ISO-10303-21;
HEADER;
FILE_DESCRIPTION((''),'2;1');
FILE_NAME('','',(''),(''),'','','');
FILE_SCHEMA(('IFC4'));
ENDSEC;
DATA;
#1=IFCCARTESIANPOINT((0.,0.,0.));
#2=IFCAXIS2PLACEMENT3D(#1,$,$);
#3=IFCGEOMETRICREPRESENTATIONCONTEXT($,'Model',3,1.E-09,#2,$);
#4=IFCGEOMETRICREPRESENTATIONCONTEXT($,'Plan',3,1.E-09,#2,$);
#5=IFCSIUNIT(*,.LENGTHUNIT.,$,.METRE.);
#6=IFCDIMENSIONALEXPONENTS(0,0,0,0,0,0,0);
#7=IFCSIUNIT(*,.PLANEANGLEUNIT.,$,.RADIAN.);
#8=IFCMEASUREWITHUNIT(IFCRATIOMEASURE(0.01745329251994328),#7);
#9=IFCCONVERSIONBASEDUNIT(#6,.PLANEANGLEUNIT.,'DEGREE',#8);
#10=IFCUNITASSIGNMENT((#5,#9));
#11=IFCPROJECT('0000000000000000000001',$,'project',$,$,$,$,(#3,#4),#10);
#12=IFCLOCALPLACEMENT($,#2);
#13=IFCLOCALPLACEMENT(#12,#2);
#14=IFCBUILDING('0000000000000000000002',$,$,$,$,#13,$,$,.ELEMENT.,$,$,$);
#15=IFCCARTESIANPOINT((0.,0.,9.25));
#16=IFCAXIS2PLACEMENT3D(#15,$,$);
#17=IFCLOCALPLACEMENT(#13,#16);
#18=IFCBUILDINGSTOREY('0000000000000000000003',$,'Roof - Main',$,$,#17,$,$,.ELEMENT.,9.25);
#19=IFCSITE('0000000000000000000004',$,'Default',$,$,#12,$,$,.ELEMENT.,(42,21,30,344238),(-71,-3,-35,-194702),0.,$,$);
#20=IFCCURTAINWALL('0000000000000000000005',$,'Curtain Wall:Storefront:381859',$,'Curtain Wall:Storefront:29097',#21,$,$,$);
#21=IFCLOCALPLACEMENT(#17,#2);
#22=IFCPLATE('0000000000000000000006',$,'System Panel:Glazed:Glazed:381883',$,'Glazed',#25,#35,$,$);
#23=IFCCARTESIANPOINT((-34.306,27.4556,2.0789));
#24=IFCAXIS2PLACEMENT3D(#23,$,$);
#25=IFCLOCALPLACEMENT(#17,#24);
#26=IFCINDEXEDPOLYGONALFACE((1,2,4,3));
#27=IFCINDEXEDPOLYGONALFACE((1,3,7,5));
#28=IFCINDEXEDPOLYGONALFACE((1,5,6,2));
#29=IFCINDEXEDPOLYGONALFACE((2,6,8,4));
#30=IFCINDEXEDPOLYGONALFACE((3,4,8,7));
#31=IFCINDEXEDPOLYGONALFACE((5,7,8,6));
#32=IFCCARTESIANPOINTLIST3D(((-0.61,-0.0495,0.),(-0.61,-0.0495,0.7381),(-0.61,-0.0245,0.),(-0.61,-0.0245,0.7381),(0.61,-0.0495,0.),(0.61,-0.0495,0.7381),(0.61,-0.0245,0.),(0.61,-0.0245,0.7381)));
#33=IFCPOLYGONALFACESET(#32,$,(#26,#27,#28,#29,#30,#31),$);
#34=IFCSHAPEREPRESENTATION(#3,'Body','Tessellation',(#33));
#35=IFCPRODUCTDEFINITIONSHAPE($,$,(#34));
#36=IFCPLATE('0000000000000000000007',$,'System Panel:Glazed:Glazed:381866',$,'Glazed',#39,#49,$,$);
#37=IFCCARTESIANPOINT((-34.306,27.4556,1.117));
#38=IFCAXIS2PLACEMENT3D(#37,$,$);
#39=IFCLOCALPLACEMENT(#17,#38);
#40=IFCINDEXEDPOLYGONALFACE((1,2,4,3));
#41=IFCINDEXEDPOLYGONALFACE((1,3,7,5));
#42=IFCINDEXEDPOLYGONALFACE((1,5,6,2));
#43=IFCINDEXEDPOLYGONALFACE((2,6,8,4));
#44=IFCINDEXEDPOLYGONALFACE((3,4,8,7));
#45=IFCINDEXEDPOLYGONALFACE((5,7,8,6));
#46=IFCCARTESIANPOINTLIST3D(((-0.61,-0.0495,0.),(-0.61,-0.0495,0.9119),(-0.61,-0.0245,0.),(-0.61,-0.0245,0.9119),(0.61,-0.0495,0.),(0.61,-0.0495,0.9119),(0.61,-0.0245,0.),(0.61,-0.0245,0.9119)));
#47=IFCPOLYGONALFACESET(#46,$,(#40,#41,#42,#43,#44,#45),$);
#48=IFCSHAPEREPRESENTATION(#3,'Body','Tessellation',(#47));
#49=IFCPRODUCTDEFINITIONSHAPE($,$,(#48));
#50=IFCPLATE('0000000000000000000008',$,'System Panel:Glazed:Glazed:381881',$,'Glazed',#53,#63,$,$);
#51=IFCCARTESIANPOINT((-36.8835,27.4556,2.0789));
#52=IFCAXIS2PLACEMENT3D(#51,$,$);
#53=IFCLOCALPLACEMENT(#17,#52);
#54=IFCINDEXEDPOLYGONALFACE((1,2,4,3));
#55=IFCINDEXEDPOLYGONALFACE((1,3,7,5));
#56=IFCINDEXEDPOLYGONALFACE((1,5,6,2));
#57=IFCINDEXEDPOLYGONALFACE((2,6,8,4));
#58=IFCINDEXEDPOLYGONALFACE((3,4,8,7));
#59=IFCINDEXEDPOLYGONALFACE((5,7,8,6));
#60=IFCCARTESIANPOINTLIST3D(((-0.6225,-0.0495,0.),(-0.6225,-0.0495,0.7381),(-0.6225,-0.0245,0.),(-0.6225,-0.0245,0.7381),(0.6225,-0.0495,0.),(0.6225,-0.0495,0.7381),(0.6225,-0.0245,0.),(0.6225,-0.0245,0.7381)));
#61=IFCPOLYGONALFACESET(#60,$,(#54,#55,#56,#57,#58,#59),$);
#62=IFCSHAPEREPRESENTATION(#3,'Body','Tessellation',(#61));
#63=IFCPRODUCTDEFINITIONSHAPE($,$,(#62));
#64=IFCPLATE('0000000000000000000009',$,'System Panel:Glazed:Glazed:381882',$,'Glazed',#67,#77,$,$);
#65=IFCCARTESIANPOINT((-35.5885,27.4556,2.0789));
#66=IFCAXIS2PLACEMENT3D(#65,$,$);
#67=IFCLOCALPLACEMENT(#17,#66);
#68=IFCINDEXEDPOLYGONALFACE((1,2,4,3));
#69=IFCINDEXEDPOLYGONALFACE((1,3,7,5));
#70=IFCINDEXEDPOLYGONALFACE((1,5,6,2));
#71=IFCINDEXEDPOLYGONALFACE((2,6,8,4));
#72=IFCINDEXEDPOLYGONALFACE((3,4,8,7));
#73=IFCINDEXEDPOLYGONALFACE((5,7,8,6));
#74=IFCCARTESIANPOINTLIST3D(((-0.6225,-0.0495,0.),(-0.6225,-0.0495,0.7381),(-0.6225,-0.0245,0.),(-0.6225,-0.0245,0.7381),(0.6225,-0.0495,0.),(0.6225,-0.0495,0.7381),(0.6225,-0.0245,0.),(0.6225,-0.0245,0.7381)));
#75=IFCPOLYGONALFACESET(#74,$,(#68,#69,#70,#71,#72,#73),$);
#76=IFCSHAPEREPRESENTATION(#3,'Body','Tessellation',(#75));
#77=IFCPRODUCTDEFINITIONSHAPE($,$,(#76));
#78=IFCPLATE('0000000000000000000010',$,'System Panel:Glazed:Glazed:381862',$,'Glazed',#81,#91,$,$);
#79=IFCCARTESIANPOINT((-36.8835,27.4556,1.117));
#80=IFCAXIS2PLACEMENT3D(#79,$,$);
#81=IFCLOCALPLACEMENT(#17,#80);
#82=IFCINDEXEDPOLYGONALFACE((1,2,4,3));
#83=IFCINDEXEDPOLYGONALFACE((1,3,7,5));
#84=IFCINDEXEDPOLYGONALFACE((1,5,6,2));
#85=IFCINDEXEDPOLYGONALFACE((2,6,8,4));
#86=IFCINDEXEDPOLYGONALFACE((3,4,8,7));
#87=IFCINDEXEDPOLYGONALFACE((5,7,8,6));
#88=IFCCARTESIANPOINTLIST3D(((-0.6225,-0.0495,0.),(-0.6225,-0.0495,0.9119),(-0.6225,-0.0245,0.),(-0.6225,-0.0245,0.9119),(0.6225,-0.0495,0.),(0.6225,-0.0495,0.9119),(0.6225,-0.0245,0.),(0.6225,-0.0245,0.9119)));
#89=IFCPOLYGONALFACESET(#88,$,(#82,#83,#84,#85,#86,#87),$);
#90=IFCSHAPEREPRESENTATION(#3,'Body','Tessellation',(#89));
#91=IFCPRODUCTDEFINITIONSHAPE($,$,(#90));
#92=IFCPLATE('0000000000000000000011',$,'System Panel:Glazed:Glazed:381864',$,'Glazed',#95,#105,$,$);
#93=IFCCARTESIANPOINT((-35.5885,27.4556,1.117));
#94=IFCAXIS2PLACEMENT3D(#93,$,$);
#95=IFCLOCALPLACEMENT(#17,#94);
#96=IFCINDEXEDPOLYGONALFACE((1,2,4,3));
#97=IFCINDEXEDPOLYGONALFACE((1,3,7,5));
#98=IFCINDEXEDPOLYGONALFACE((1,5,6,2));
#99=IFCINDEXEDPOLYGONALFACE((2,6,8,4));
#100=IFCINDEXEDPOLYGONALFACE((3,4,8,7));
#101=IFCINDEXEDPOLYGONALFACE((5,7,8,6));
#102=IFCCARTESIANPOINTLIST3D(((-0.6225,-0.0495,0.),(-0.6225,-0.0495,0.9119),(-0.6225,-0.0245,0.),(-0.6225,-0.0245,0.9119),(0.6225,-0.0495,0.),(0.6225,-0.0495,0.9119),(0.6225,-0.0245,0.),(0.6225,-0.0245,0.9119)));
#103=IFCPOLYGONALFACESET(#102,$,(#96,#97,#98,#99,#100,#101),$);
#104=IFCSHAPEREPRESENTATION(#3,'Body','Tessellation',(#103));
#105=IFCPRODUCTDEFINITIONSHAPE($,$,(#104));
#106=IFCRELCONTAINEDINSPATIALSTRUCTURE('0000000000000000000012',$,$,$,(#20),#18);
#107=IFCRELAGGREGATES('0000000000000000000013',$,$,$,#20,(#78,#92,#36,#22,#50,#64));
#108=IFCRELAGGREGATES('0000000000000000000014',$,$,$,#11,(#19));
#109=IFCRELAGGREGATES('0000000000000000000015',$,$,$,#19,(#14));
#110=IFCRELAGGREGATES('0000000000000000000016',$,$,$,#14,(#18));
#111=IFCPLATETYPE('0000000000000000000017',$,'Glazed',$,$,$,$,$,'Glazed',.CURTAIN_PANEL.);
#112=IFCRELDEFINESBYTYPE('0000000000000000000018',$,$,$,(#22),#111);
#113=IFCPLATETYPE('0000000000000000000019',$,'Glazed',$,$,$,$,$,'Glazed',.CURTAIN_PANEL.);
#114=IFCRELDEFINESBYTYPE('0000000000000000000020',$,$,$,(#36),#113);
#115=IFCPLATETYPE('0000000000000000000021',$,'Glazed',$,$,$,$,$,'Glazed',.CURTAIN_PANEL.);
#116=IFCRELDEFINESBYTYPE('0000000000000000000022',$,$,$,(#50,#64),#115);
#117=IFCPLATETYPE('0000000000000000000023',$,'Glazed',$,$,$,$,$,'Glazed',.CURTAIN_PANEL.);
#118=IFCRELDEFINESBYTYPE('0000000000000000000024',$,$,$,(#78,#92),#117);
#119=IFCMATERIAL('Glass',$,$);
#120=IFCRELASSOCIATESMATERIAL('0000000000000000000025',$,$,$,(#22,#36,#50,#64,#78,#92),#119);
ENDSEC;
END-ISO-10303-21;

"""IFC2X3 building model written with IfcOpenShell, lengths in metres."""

from ifc_helpers import new_model, entity, si_unit, converted_unit, frame, origin, origin_2d_with_axis, place, context, project, spatial, rectangle, extrude, source, transform, mapped, material, type_object, type_shapes, element, aggregate, save


model = new_model("IFC2X3")

# Units and contexts
model_context = context("Model", 3, precision=1e-09, world=origin())
plan_context = context("Plan", 3, precision=1e-09, world=origin())
ifc_project = project(units=[si_unit("LENGTHUNIT", "METRE"), converted_unit("PLANEANGLEUNIT", "DEGREE", entity("IfcRatioMeasure", 0.01745329251994328), si_unit("PLANEANGLEUNIT", "RADIAN"), dimensions=[0, 0, 0, 0, 0, 0, 0])], contexts=[model_context, plan_context])

# Site, building, storey
site_placement = place(None, origin())
site = spatial("IfcSite", under=ifc_project, at=site_placement, Name="Default", CompositionType="ELEMENT", RefLatitude=(42, 21, 30, 344238), RefLongitude=(-71, -3, -35, -194702), RefElevation=0.0)
building_placement = place(site_placement, origin())
building = spatial("IfcBuilding", under=site, at=building_placement, CompositionType="ELEMENT")
storey_placement = place(building_placement, frame((0.0, 0.0, 9.25)))
storey = spatial("IfcBuildingStorey", under=building, at=storey_placement, Name="Roof - Main", CompositionType="ELEMENT", Elevation=9.25)

# Curtain wall, plates
curtain_wall_placement = place(storey_placement, origin())
curtain_wall = element("IfcCurtainWall", 1, at=curtain_wall_placement, inside=storey, Name="Curtain Wall:Storefront:381859", ObjectType="Curtain Wall:Storefront:29097")
ifc_material_1 = material(Name="Glass")
plate_type_1 = type_object("IfcPlateType", Name="Glazed", ElementType="Glazed", PredefinedType="CURTAIN_PANEL")
shared_shape_1 = source(origin(), model_context, "Body", "SweptSolid", [
    extrude(rectangle(XDim=0.025, YDim=1.22, at=origin_2d_with_axis()), frame((0.0, -0.037, 0.0), z_axis=(0.0, 0.0, 1.0), x_axis=(0.0, 1.0, 0.0)), (0.0, 0.0, 1.0), 0.7381),
])
type_shapes(plate_type_1, [shared_shape_1])
plate_1_placement = place(storey_placement, frame((-34.306, 27.4556, 2.0789)))
plate_1 = element("IfcPlate", 2, at=plate_1_placement, type_object=plate_type_1, material=ifc_material_1, Name="System Panel:Glazed:Glazed:381883", ObjectType="Glazed", context=model_context, shape_type="MappedRepresentation", body=[
    mapped(shared_shape_1, transform((0.0, 0.0, 0.0), scale=1.0)),
])
plate_type_2 = type_object("IfcPlateType", Name="Glazed", ElementType="Glazed", PredefinedType="CURTAIN_PANEL")
shared_shape_2 = source(origin(), model_context, "Body", "SweptSolid", [
    extrude(rectangle(XDim=0.025, YDim=1.22, at=origin_2d_with_axis()), frame((0.0, -0.037, 0.0), z_axis=(0.0, 0.0, 1.0), x_axis=(0.0, 1.0, 0.0)), (0.0, 0.0, 1.0), 0.9119),
])
type_shapes(plate_type_2, [shared_shape_2])
plate_2_placement = place(storey_placement, frame((-34.306, 27.4556, 1.117)))
plate_2 = element("IfcPlate", 3, at=plate_2_placement, type_object=plate_type_2, material=ifc_material_1, Name="System Panel:Glazed:Glazed:381866", ObjectType="Glazed", context=model_context, shape_type="MappedRepresentation", body=[
    mapped(shared_shape_2, transform((0.0, 0.0, 0.0), scale=1.0)),
])
plate_type_3 = type_object("IfcPlateType", Name="Glazed", ElementType="Glazed", PredefinedType="CURTAIN_PANEL")
shared_shape_3 = source(origin(), model_context, "Body", "SweptSolid", [
    extrude(rectangle(XDim=0.025, YDim=1.245, at=origin_2d_with_axis()), frame((0.0, -0.037, 0.0), z_axis=(0.0, 0.0, 1.0), x_axis=(0.0, 1.0, 0.0)), (0.0, 0.0, 1.0), 0.7381),
])
type_shapes(plate_type_3, [shared_shape_3])
plate_3_placement = place(storey_placement, frame((-36.8835, 27.4556, 2.0789)))
plate_3 = element("IfcPlate", 4, at=plate_3_placement, type_object=plate_type_3, material=ifc_material_1, Name="System Panel:Glazed:Glazed:381881", ObjectType="Glazed", context=model_context, shape_type="MappedRepresentation", body=[
    mapped(shared_shape_3, transform((0.0, 0.0, 0.0), scale=1.0)),
])
plate_4_placement = place(storey_placement, frame((-35.5885, 27.4556, 2.0789)))
plate_4 = element("IfcPlate", 5, at=plate_4_placement, type_object=plate_type_3, material=ifc_material_1, Name="System Panel:Glazed:Glazed:381882", ObjectType="Glazed", context=model_context, shape_type="MappedRepresentation", body=[
    mapped(shared_shape_3, transform((0.0, 0.0, 0.0), scale=1.0)),
])
plate_type_4 = type_object("IfcPlateType", Name="Glazed", ElementType="Glazed", PredefinedType="CURTAIN_PANEL")
shared_shape_4 = source(origin(), model_context, "Body", "SweptSolid", [
    extrude(rectangle(XDim=0.025, YDim=1.245, at=origin_2d_with_axis()), frame((0.0, -0.037, 0.0), z_axis=(0.0, 0.0, 1.0), x_axis=(0.0, 1.0, 0.0)), (0.0, 0.0, 1.0), 0.9119),
])
type_shapes(plate_type_4, [shared_shape_4])
plate_5_placement = place(storey_placement, frame((-36.8835, 27.4556, 1.117)))
plate_5 = element("IfcPlate", 6, at=plate_5_placement, type_object=plate_type_4, material=ifc_material_1, Name="System Panel:Glazed:Glazed:381862", ObjectType="Glazed", context=model_context, shape_type="MappedRepresentation", body=[
    mapped(shared_shape_4, transform((0.0, 0.0, 0.0), scale=1.0)),
])
plate_6_placement = place(storey_placement, frame((-35.5885, 27.4556, 1.117)))
plate_6 = element("IfcPlate", 7, at=plate_6_placement, type_object=plate_type_4, material=ifc_material_1, Name="System Panel:Glazed:Glazed:381864", ObjectType="Glazed", context=model_context, shape_type="MappedRepresentation", body=[
    mapped(shared_shape_4, transform((0.0, 0.0, 0.0), scale=1.0)),
])
aggregate(curtain_wall, [plate_5, plate_6, plate_2, plate_1, plate_3, plate_4])

save(model, "model.ifc")
